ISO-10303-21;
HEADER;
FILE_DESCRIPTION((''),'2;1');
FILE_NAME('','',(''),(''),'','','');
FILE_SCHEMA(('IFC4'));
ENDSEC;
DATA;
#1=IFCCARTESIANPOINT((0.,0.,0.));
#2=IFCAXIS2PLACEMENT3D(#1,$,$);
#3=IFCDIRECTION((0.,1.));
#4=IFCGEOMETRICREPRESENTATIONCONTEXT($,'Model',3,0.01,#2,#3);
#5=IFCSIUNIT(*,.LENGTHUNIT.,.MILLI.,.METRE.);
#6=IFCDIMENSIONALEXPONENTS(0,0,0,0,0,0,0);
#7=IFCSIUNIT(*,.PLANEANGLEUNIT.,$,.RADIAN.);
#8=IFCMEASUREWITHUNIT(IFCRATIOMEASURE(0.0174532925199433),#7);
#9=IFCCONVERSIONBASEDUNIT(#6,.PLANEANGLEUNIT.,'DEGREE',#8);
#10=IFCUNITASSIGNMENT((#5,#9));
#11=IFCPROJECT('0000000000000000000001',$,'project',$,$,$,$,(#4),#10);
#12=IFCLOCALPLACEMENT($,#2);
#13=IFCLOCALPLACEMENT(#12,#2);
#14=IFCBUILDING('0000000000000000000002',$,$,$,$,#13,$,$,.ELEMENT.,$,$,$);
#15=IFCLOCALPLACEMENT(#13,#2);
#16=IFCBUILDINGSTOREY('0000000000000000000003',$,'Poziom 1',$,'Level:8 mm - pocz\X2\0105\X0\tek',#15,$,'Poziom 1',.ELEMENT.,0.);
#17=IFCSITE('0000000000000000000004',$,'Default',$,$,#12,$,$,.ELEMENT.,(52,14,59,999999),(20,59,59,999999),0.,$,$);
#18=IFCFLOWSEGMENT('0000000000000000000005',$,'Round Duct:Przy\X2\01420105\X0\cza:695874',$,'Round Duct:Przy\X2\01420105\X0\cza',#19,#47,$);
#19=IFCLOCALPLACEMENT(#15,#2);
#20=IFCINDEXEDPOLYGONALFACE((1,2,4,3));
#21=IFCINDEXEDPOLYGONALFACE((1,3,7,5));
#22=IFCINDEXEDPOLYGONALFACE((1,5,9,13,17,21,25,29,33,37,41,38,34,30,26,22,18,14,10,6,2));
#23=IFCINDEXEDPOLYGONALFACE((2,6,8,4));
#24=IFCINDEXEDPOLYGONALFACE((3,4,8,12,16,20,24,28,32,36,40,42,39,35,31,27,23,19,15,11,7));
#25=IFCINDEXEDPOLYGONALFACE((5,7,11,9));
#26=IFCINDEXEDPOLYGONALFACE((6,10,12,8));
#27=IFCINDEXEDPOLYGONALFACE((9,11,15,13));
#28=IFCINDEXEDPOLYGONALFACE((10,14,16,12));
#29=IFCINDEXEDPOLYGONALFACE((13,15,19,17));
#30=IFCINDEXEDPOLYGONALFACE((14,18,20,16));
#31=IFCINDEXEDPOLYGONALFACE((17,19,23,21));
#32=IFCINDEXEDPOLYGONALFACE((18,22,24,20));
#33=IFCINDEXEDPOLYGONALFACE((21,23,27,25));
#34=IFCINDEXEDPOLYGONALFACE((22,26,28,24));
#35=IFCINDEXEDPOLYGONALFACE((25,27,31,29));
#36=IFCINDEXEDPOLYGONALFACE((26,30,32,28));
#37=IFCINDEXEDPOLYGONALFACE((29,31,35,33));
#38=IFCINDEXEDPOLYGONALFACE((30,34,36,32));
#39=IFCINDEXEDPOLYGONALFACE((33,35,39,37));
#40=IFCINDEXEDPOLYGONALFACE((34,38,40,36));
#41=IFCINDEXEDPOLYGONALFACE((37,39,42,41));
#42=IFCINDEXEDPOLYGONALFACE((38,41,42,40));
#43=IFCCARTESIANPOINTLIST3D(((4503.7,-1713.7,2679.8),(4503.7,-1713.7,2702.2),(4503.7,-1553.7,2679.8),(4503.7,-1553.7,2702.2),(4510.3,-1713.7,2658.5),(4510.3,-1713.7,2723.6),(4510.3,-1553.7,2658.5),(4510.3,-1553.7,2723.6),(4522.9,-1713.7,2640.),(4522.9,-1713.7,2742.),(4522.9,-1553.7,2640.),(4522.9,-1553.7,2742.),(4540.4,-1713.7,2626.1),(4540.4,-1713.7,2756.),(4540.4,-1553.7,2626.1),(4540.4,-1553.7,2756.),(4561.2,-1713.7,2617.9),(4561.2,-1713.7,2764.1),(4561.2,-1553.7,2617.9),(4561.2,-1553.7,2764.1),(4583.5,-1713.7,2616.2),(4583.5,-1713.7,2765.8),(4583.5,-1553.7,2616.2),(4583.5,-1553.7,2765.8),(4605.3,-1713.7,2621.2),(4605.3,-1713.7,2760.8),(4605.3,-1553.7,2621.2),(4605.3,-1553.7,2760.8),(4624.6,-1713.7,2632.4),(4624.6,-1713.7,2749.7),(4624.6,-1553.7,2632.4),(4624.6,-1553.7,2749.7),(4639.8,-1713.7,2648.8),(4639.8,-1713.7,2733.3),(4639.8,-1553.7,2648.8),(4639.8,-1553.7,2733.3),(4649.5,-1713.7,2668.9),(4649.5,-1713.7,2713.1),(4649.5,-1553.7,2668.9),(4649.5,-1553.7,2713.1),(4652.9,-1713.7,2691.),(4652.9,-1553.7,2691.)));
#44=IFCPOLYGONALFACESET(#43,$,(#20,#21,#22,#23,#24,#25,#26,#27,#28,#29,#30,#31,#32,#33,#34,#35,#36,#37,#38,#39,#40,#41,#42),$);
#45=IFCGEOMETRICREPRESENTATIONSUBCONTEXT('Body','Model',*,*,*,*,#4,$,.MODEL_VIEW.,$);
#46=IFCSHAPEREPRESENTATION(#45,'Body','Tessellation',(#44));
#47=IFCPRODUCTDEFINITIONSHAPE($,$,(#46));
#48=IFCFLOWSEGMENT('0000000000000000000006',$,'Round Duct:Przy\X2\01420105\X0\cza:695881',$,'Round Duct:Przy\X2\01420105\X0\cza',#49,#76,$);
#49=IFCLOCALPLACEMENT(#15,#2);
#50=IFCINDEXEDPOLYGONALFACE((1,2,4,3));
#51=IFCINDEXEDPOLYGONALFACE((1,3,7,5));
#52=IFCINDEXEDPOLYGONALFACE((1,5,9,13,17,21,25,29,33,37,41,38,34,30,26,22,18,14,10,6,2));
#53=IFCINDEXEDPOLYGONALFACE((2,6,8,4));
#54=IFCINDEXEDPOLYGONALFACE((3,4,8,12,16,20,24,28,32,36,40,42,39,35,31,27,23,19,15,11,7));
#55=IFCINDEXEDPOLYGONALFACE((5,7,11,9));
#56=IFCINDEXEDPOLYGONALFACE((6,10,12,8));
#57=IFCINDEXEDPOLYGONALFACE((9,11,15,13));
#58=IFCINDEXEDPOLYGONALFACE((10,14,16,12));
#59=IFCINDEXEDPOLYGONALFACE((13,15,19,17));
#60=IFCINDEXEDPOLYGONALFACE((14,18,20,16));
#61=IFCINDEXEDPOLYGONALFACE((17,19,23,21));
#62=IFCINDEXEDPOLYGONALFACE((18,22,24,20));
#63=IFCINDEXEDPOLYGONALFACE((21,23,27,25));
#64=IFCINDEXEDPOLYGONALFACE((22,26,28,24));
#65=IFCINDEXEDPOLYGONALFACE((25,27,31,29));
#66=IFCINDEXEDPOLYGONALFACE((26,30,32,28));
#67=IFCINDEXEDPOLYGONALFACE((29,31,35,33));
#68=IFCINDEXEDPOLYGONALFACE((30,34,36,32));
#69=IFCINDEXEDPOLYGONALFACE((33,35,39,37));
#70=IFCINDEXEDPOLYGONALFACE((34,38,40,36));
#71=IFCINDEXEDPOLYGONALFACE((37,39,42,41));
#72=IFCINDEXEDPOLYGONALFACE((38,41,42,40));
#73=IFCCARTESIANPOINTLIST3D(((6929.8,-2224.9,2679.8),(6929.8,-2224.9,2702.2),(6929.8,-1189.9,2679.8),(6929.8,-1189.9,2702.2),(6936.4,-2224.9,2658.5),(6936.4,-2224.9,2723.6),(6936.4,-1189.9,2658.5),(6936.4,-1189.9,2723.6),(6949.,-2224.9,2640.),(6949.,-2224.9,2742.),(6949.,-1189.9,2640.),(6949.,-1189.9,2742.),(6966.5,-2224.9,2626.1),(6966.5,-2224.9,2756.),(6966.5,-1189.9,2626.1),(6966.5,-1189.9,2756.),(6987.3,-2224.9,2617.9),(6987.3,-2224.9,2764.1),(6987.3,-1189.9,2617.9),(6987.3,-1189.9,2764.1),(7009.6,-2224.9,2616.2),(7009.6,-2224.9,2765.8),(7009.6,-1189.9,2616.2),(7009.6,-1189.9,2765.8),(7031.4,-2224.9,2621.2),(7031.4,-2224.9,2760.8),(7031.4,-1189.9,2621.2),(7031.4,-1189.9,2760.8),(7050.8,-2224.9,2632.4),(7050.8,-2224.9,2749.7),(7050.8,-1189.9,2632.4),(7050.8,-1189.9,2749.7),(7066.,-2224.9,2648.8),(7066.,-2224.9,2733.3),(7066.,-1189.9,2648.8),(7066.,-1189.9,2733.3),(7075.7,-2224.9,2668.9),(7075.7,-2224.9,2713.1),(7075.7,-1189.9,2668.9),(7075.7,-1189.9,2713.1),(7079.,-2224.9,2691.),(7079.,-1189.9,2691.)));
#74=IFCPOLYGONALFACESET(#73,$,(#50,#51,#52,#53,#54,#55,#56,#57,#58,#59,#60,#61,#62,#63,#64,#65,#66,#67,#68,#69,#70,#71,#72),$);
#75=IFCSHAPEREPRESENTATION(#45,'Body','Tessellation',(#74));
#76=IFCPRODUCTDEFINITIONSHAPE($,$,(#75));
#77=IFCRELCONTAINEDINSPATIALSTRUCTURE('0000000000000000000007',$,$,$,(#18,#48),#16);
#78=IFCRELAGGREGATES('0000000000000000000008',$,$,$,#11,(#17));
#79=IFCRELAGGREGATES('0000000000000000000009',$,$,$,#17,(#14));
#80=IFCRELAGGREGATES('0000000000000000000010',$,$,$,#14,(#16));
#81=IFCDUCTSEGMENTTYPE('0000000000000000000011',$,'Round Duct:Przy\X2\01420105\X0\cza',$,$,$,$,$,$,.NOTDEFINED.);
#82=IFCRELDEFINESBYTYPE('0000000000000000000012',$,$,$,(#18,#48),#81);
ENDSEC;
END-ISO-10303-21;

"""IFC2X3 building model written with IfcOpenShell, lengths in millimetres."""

from ifc_helpers import new_model, entity, si_unit, converted_unit, direction, frame, frame_2d, origin, origin_2d_with_axis, place, context, subcontext, project, spatial, circle, extrude, type_object, element, save


model = new_model("IFC2X3")

# Units and contexts
model_context = context("Model", 3, precision=0.01, world=origin(), true_north=direction((0.0, 1.0)))
body_context = subcontext(model_context, "Body", "Model", "MODEL_VIEW")
ifc_project = project(units=[si_unit("LENGTHUNIT", "METRE", prefix="MILLI"), converted_unit("PLANEANGLEUNIT", "DEGREE", entity("IfcRatioMeasure", 0.0174532925199433), si_unit("PLANEANGLEUNIT", "RADIAN"), dimensions=[0, 0, 0, 0, 0, 0, 0])], contexts=[model_context])

# Site, building, storey
site_placement = place(None, origin())
site = spatial("IfcSite", under=ifc_project, at=site_placement, Name="Default", CompositionType="ELEMENT", RefLatitude=(52, 14, 59, 999999), RefLongitude=(20, 59, 59, 999999), RefElevation=0.0)
building_placement = place(site_placement, origin())
building = spatial("IfcBuilding", under=site, at=building_placement, CompositionType="ELEMENT")
storey_placement = place(building_placement, origin())
storey = spatial("IfcBuildingStorey", under=building, at=storey_placement, Name="Poziom 1", ObjectType="Level:8 mm - początek", LongName="Poziom 1", CompositionType="ELEMENT", Elevation=0.0)

# Flow segments
duct_segment_type_1 = type_object("IfcDuctSegmentType", Name="Round Duct:Przyłącza", PredefinedType="NOTDEFINED")
flow_segment_1_placement = place(storey_placement, origin())
element("IfcFlowSegment", 1, at=flow_segment_1_placement, inside=storey, type_object=duct_segment_type_1, Name="Round Duct:Przyłącza:695874", ObjectType="Round Duct:Przyłącza", context=body_context, shape_type="SweptSolid", body=[
    extrude(circle(Radius=75.0, at=frame_2d((0.0, 0.0), x_axis=(1.0, 0.0))), frame((4577.9, -1713.7, 2691.0), z_axis=(0.0, 1.0, 0.0), x_axis=(1.0, 0.0, 0.0)), (0.0, 0.0, 1.0), 160.0),
])
flow_segment_2_placement = place(storey_placement, origin())
element("IfcFlowSegment", 2, at=flow_segment_2_placement, inside=storey, type_object=duct_segment_type_1, Name="Round Duct:Przyłącza:695881", ObjectType="Round Duct:Przyłącza", context=body_context, shape_type="SweptSolid", body=[
    extrude(circle(Radius=75.0, at=origin_2d_with_axis()), frame((7004.0, -2224.9, 2691.0), z_axis=(0.0, 1.0, 0.0), x_axis=(1.0, 0.0, 0.0)), (0.0, 0.0, 1.0), 1035.0),
])

save(model, "model.ifc")
